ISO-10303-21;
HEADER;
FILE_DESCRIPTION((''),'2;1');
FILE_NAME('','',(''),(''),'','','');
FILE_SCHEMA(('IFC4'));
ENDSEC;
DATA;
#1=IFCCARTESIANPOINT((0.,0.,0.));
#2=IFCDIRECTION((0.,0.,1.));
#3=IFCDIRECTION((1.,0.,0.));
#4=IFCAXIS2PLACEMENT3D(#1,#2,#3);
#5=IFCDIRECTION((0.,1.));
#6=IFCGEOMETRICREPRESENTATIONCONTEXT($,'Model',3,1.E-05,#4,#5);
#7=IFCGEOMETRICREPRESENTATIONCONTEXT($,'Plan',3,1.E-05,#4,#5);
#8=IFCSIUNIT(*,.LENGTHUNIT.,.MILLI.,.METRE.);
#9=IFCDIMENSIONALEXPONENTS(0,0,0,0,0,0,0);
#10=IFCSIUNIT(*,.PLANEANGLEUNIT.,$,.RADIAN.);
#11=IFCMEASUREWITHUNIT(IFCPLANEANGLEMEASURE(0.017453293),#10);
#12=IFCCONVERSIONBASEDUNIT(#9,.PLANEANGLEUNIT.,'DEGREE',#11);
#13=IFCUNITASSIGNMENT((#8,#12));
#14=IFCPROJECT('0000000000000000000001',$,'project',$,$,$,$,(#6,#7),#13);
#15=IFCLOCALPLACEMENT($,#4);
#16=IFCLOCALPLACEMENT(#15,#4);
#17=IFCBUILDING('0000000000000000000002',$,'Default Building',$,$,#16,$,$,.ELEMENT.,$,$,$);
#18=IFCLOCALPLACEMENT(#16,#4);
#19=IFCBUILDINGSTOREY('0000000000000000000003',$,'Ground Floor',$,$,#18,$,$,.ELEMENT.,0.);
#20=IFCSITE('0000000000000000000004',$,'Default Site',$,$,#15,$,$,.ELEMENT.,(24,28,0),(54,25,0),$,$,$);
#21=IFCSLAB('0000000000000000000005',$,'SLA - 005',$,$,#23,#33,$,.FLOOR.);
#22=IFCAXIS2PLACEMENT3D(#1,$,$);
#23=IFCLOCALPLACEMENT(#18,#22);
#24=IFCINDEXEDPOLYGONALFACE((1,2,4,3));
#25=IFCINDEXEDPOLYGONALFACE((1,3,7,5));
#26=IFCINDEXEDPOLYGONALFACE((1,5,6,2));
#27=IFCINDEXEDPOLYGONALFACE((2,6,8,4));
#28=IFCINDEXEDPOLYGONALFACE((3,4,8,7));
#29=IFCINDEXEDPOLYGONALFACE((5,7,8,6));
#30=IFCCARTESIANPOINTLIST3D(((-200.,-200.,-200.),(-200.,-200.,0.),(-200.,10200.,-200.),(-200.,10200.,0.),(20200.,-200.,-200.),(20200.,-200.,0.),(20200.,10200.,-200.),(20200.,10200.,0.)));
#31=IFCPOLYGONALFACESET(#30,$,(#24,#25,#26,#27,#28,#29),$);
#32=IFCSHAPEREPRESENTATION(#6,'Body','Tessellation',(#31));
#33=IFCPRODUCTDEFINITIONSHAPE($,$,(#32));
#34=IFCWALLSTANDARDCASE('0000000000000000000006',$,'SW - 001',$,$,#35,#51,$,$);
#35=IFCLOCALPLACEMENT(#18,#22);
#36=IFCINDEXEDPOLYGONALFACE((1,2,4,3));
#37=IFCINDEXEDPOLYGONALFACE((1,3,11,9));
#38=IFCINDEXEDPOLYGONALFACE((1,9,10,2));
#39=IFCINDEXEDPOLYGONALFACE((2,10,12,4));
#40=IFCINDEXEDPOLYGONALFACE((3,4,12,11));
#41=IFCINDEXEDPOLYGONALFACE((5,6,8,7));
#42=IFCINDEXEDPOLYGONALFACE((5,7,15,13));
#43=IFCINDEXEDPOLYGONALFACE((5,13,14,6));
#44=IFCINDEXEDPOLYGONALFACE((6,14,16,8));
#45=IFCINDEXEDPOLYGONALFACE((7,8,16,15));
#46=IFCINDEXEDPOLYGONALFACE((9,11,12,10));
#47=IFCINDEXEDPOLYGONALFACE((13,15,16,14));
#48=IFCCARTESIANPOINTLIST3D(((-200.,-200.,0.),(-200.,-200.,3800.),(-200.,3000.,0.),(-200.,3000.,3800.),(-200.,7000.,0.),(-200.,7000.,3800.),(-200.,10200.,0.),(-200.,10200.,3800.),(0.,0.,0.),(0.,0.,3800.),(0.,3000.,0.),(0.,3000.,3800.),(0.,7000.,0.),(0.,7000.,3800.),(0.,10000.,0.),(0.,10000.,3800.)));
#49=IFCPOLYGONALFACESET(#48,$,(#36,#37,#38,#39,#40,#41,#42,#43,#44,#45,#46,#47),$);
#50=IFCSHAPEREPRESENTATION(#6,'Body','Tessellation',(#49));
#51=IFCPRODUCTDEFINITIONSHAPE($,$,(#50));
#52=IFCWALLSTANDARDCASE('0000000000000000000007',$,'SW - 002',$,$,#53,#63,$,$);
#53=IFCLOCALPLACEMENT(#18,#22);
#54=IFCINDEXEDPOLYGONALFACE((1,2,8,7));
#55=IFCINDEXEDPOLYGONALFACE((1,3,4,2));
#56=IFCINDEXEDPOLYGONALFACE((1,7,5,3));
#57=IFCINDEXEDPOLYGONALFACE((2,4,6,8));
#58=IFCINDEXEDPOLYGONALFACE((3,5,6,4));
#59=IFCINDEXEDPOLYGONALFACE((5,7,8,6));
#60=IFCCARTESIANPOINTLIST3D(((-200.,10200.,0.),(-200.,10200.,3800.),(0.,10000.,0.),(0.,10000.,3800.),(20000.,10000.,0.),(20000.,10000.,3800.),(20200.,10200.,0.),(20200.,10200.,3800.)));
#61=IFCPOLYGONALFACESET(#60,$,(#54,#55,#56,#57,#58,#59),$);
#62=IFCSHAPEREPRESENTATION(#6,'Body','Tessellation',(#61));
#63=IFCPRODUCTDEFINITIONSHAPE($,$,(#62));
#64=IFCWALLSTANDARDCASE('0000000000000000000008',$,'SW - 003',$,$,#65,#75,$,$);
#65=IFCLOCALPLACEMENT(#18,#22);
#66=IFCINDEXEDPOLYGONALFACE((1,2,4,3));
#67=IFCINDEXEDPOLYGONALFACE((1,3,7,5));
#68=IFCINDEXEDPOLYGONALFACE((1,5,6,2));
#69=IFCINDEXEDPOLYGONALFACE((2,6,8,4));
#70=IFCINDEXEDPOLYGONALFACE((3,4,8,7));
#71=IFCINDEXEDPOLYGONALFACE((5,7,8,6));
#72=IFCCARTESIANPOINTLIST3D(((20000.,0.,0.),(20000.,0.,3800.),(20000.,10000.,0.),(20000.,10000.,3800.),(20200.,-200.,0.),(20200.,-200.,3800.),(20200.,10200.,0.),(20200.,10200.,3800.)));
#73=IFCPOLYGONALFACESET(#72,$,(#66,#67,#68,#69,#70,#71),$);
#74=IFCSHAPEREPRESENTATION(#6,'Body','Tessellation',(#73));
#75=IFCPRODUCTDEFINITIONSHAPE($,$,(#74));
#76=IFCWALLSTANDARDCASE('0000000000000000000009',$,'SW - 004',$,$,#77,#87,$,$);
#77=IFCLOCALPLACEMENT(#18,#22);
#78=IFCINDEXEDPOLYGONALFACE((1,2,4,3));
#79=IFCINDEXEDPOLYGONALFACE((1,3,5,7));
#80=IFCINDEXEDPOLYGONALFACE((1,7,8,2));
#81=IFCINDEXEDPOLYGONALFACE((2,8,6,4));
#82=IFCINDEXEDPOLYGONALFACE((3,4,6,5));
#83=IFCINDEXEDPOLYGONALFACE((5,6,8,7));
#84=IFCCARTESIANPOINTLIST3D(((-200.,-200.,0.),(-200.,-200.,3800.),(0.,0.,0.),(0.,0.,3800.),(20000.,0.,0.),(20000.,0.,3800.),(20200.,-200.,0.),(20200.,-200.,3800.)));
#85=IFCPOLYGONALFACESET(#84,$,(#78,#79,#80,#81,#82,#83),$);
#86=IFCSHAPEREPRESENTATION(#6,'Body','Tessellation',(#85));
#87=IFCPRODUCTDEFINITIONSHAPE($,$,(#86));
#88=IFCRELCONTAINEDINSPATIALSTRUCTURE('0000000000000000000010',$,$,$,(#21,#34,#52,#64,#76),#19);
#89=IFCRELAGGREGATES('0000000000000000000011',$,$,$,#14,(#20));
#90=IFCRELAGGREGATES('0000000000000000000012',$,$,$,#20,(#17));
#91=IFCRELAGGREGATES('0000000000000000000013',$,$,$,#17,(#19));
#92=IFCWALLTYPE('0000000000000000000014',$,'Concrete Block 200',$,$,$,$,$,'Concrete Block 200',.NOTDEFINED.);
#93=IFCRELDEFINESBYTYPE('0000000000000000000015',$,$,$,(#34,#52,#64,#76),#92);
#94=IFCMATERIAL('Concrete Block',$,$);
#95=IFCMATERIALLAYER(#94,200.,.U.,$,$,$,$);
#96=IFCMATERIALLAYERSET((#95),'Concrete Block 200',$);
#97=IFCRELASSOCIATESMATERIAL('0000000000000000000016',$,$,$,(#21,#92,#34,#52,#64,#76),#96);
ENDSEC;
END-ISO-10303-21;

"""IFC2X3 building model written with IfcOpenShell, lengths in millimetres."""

from ifc_helpers import new_model, entity, si_unit, converted_unit, direction, frame, frame_2d, origin_with_axes, place, context, project, spatial, polyline, rectangle, outline, extrude, material, layer, layer_set, layer_usage, type_object, element, save


model = new_model("IFC2X3")

# Units and contexts
model_context = context("Model", 3, precision=1e-05, world=origin_with_axes(), true_north=direction((0.0, 1.0)))
plan_context = context("Plan", 3, precision=1e-05, world=origin_with_axes(), true_north=direction((0.0, 1.0)))
ifc_project = project(units=[si_unit("LENGTHUNIT", "METRE", prefix="MILLI"), converted_unit("PLANEANGLEUNIT", "DEGREE", entity("IfcPlaneAngleMeasure", 0.017453293), si_unit("PLANEANGLEUNIT", "RADIAN"), dimensions=[0, 0, 0, 0, 0, 0, 0])], contexts=[model_context, plan_context])

# Site, building, storey
site_placement = place(None, origin_with_axes())
site = spatial("IfcSite", under=ifc_project, at=site_placement, Name="Default Site", CompositionType="ELEMENT", RefLatitude=(24, 28, 0), RefLongitude=(54, 25, 0))
building_placement = place(site_placement, origin_with_axes())
building = spatial("IfcBuilding", under=site, at=building_placement, Name="Default Building", CompositionType="ELEMENT")
storey_placement = place(building_placement, origin_with_axes())
storey = spatial("IfcBuildingStorey", under=building, at=storey_placement, Name="Ground Floor", CompositionType="ELEMENT", Elevation=0.0)

# Slab
ifc_material = material(Name="Concrete Block")
ifc_layer = layer(ifc_material, 200.0, ventilated="UNKNOWN")
ifc_layer_set = layer_set([ifc_layer], Name="Concrete Block 200")
ifc_layer_usage_1 = layer_usage(ifc_layer_set, "AXIS3", "NEGATIVE", 200.0)
slab_placement = place(storey_placement, frame((-200.0, 10200.0, -200.0), z_axis=(0.0, 0.0, 1.0), x_axis=(1.0, 0.0, 0.0)))
element("IfcSlab", 1, at=slab_placement, inside=storey, material=ifc_layer_usage_1, Name="SLA - 005", PredefinedType="FLOOR", context=model_context, shape_type="SweptSolid", body=[
    extrude(outline(polyline([(0.0, 0.0), (20400.0, 0.0), (20400.0, -10400.0), (0.0, -10400.0), (0.0, 0.0)])), origin_with_axes(), (0.0, 0.0, 1.0), 200.0),
])

# Wall, opening
ifc_layer_usage_2 = layer_usage(ifc_layer_set, "AXIS2", "POSITIVE", 0.0)
wall_type = type_object("IfcWallType", Name="Concrete Block 200", ElementType="Concrete Block 200", PredefinedType="NOTDEFINED", material=ifc_layer_set)
wall_1_placement = place(storey_placement, frame((0.0, 0.0, 0.0), z_axis=(0.0, 0.0, 1.0), x_axis=(0.0, 1.0, 0.0)))
wall_1 = element("IfcWallStandardCase", 2, at=wall_1_placement, inside=storey, type_object=wall_type, material=ifc_layer_usage_2, Name="SW - 001", context=model_context, shape_type="SweptSolid", body=[
    extrude(outline(polyline([(0.0, 0.0), (10000.0, 0.0), (10200.0, 200.0), (-200.0, 200.0), (0.0, 0.0)])), origin_with_axes(), (0.0, 0.0, 1.0), 3800.0),
])
opening_placement = place(wall_1_placement, frame((5000.0, 0.0, 0.0), z_axis=(0.0, 0.0, 1.0), x_axis=(1.0, 0.0, 0.0)))
element("IfcOpeningElement", 3, at=opening_placement, cuts=wall_1, ObjectType="Opening", context=model_context, shape_type="SweptSolid", body=[
    extrude(rectangle(XDim=4000.0, YDim=3800.0, at=frame_2d((0.0, 1900.0), x_axis=(1.0, 0.0))), frame((0.0, 0.0, 0.0), z_axis=(0.0, 1.0, 0.0), x_axis=(-1.0, 0.0, 0.0)), (0.0, 0.0, 1.0), 200.0),
])

# Walls
ifc_layer_usage_3 = layer_usage(ifc_layer_set, "AXIS2", "POSITIVE", 0.0)
wall_2_placement = place(storey_placement, frame((0.0, 10000.0, 0.0), z_axis=(0.0, 0.0, 1.0), x_axis=(1.0, 0.0, 0.0)))
element("IfcWallStandardCase", 4, at=wall_2_placement, inside=storey, type_object=wall_type, material=ifc_layer_usage_3, Name="SW - 002", context=model_context, shape_type="SweptSolid", body=[
    extrude(outline(polyline([(0.0, 0.0), (20000.0, 0.0), (20200.0, 200.0), (-200.0, 200.0), (0.0, 0.0)])), origin_with_axes(), (0.0, 0.0, 1.0), 3800.0),
])
ifc_layer_usage_4 = layer_usage(ifc_layer_set, "AXIS2", "POSITIVE", 0.0)
wall_3_placement = place(storey_placement, frame((20000.0, 10000.0, 0.0), z_axis=(0.0, 0.0, 1.0), x_axis=(0.0, -1.0, 0.0)))
element("IfcWallStandardCase", 5, at=wall_3_placement, inside=storey, type_object=wall_type, material=ifc_layer_usage_4, Name="SW - 003", context=model_context, shape_type="SweptSolid", body=[
    extrude(outline(polyline([(0.0, 0.0), (10000.0, 0.0), (10200.0, 200.0), (-200.0, 200.0), (0.0, 0.0)])), origin_with_axes(), (0.0, 0.0, 1.0), 3800.0),
])
ifc_layer_usage_5 = layer_usage(ifc_layer_set, "AXIS2", "POSITIVE", 0.0)
wall_4_placement = place(storey_placement, frame((20000.0, 0.0, 0.0), z_axis=(0.0, 0.0, 1.0), x_axis=(-1.0, 0.0, 0.0)))
element("IfcWallStandardCase", 6, at=wall_4_placement, inside=storey, type_object=wall_type, material=ifc_layer_usage_5, Name="SW - 004", context=model_context, shape_type="SweptSolid", body=[
    extrude(outline(polyline([(0.0, 0.0), (20000.0, 0.0), (20200.0, 200.0), (-200.0, 200.0), (0.0, 0.0)])), origin_with_axes(), (0.0, 0.0, 1.0), 3800.0),
])

save(model, "model.ifc")
